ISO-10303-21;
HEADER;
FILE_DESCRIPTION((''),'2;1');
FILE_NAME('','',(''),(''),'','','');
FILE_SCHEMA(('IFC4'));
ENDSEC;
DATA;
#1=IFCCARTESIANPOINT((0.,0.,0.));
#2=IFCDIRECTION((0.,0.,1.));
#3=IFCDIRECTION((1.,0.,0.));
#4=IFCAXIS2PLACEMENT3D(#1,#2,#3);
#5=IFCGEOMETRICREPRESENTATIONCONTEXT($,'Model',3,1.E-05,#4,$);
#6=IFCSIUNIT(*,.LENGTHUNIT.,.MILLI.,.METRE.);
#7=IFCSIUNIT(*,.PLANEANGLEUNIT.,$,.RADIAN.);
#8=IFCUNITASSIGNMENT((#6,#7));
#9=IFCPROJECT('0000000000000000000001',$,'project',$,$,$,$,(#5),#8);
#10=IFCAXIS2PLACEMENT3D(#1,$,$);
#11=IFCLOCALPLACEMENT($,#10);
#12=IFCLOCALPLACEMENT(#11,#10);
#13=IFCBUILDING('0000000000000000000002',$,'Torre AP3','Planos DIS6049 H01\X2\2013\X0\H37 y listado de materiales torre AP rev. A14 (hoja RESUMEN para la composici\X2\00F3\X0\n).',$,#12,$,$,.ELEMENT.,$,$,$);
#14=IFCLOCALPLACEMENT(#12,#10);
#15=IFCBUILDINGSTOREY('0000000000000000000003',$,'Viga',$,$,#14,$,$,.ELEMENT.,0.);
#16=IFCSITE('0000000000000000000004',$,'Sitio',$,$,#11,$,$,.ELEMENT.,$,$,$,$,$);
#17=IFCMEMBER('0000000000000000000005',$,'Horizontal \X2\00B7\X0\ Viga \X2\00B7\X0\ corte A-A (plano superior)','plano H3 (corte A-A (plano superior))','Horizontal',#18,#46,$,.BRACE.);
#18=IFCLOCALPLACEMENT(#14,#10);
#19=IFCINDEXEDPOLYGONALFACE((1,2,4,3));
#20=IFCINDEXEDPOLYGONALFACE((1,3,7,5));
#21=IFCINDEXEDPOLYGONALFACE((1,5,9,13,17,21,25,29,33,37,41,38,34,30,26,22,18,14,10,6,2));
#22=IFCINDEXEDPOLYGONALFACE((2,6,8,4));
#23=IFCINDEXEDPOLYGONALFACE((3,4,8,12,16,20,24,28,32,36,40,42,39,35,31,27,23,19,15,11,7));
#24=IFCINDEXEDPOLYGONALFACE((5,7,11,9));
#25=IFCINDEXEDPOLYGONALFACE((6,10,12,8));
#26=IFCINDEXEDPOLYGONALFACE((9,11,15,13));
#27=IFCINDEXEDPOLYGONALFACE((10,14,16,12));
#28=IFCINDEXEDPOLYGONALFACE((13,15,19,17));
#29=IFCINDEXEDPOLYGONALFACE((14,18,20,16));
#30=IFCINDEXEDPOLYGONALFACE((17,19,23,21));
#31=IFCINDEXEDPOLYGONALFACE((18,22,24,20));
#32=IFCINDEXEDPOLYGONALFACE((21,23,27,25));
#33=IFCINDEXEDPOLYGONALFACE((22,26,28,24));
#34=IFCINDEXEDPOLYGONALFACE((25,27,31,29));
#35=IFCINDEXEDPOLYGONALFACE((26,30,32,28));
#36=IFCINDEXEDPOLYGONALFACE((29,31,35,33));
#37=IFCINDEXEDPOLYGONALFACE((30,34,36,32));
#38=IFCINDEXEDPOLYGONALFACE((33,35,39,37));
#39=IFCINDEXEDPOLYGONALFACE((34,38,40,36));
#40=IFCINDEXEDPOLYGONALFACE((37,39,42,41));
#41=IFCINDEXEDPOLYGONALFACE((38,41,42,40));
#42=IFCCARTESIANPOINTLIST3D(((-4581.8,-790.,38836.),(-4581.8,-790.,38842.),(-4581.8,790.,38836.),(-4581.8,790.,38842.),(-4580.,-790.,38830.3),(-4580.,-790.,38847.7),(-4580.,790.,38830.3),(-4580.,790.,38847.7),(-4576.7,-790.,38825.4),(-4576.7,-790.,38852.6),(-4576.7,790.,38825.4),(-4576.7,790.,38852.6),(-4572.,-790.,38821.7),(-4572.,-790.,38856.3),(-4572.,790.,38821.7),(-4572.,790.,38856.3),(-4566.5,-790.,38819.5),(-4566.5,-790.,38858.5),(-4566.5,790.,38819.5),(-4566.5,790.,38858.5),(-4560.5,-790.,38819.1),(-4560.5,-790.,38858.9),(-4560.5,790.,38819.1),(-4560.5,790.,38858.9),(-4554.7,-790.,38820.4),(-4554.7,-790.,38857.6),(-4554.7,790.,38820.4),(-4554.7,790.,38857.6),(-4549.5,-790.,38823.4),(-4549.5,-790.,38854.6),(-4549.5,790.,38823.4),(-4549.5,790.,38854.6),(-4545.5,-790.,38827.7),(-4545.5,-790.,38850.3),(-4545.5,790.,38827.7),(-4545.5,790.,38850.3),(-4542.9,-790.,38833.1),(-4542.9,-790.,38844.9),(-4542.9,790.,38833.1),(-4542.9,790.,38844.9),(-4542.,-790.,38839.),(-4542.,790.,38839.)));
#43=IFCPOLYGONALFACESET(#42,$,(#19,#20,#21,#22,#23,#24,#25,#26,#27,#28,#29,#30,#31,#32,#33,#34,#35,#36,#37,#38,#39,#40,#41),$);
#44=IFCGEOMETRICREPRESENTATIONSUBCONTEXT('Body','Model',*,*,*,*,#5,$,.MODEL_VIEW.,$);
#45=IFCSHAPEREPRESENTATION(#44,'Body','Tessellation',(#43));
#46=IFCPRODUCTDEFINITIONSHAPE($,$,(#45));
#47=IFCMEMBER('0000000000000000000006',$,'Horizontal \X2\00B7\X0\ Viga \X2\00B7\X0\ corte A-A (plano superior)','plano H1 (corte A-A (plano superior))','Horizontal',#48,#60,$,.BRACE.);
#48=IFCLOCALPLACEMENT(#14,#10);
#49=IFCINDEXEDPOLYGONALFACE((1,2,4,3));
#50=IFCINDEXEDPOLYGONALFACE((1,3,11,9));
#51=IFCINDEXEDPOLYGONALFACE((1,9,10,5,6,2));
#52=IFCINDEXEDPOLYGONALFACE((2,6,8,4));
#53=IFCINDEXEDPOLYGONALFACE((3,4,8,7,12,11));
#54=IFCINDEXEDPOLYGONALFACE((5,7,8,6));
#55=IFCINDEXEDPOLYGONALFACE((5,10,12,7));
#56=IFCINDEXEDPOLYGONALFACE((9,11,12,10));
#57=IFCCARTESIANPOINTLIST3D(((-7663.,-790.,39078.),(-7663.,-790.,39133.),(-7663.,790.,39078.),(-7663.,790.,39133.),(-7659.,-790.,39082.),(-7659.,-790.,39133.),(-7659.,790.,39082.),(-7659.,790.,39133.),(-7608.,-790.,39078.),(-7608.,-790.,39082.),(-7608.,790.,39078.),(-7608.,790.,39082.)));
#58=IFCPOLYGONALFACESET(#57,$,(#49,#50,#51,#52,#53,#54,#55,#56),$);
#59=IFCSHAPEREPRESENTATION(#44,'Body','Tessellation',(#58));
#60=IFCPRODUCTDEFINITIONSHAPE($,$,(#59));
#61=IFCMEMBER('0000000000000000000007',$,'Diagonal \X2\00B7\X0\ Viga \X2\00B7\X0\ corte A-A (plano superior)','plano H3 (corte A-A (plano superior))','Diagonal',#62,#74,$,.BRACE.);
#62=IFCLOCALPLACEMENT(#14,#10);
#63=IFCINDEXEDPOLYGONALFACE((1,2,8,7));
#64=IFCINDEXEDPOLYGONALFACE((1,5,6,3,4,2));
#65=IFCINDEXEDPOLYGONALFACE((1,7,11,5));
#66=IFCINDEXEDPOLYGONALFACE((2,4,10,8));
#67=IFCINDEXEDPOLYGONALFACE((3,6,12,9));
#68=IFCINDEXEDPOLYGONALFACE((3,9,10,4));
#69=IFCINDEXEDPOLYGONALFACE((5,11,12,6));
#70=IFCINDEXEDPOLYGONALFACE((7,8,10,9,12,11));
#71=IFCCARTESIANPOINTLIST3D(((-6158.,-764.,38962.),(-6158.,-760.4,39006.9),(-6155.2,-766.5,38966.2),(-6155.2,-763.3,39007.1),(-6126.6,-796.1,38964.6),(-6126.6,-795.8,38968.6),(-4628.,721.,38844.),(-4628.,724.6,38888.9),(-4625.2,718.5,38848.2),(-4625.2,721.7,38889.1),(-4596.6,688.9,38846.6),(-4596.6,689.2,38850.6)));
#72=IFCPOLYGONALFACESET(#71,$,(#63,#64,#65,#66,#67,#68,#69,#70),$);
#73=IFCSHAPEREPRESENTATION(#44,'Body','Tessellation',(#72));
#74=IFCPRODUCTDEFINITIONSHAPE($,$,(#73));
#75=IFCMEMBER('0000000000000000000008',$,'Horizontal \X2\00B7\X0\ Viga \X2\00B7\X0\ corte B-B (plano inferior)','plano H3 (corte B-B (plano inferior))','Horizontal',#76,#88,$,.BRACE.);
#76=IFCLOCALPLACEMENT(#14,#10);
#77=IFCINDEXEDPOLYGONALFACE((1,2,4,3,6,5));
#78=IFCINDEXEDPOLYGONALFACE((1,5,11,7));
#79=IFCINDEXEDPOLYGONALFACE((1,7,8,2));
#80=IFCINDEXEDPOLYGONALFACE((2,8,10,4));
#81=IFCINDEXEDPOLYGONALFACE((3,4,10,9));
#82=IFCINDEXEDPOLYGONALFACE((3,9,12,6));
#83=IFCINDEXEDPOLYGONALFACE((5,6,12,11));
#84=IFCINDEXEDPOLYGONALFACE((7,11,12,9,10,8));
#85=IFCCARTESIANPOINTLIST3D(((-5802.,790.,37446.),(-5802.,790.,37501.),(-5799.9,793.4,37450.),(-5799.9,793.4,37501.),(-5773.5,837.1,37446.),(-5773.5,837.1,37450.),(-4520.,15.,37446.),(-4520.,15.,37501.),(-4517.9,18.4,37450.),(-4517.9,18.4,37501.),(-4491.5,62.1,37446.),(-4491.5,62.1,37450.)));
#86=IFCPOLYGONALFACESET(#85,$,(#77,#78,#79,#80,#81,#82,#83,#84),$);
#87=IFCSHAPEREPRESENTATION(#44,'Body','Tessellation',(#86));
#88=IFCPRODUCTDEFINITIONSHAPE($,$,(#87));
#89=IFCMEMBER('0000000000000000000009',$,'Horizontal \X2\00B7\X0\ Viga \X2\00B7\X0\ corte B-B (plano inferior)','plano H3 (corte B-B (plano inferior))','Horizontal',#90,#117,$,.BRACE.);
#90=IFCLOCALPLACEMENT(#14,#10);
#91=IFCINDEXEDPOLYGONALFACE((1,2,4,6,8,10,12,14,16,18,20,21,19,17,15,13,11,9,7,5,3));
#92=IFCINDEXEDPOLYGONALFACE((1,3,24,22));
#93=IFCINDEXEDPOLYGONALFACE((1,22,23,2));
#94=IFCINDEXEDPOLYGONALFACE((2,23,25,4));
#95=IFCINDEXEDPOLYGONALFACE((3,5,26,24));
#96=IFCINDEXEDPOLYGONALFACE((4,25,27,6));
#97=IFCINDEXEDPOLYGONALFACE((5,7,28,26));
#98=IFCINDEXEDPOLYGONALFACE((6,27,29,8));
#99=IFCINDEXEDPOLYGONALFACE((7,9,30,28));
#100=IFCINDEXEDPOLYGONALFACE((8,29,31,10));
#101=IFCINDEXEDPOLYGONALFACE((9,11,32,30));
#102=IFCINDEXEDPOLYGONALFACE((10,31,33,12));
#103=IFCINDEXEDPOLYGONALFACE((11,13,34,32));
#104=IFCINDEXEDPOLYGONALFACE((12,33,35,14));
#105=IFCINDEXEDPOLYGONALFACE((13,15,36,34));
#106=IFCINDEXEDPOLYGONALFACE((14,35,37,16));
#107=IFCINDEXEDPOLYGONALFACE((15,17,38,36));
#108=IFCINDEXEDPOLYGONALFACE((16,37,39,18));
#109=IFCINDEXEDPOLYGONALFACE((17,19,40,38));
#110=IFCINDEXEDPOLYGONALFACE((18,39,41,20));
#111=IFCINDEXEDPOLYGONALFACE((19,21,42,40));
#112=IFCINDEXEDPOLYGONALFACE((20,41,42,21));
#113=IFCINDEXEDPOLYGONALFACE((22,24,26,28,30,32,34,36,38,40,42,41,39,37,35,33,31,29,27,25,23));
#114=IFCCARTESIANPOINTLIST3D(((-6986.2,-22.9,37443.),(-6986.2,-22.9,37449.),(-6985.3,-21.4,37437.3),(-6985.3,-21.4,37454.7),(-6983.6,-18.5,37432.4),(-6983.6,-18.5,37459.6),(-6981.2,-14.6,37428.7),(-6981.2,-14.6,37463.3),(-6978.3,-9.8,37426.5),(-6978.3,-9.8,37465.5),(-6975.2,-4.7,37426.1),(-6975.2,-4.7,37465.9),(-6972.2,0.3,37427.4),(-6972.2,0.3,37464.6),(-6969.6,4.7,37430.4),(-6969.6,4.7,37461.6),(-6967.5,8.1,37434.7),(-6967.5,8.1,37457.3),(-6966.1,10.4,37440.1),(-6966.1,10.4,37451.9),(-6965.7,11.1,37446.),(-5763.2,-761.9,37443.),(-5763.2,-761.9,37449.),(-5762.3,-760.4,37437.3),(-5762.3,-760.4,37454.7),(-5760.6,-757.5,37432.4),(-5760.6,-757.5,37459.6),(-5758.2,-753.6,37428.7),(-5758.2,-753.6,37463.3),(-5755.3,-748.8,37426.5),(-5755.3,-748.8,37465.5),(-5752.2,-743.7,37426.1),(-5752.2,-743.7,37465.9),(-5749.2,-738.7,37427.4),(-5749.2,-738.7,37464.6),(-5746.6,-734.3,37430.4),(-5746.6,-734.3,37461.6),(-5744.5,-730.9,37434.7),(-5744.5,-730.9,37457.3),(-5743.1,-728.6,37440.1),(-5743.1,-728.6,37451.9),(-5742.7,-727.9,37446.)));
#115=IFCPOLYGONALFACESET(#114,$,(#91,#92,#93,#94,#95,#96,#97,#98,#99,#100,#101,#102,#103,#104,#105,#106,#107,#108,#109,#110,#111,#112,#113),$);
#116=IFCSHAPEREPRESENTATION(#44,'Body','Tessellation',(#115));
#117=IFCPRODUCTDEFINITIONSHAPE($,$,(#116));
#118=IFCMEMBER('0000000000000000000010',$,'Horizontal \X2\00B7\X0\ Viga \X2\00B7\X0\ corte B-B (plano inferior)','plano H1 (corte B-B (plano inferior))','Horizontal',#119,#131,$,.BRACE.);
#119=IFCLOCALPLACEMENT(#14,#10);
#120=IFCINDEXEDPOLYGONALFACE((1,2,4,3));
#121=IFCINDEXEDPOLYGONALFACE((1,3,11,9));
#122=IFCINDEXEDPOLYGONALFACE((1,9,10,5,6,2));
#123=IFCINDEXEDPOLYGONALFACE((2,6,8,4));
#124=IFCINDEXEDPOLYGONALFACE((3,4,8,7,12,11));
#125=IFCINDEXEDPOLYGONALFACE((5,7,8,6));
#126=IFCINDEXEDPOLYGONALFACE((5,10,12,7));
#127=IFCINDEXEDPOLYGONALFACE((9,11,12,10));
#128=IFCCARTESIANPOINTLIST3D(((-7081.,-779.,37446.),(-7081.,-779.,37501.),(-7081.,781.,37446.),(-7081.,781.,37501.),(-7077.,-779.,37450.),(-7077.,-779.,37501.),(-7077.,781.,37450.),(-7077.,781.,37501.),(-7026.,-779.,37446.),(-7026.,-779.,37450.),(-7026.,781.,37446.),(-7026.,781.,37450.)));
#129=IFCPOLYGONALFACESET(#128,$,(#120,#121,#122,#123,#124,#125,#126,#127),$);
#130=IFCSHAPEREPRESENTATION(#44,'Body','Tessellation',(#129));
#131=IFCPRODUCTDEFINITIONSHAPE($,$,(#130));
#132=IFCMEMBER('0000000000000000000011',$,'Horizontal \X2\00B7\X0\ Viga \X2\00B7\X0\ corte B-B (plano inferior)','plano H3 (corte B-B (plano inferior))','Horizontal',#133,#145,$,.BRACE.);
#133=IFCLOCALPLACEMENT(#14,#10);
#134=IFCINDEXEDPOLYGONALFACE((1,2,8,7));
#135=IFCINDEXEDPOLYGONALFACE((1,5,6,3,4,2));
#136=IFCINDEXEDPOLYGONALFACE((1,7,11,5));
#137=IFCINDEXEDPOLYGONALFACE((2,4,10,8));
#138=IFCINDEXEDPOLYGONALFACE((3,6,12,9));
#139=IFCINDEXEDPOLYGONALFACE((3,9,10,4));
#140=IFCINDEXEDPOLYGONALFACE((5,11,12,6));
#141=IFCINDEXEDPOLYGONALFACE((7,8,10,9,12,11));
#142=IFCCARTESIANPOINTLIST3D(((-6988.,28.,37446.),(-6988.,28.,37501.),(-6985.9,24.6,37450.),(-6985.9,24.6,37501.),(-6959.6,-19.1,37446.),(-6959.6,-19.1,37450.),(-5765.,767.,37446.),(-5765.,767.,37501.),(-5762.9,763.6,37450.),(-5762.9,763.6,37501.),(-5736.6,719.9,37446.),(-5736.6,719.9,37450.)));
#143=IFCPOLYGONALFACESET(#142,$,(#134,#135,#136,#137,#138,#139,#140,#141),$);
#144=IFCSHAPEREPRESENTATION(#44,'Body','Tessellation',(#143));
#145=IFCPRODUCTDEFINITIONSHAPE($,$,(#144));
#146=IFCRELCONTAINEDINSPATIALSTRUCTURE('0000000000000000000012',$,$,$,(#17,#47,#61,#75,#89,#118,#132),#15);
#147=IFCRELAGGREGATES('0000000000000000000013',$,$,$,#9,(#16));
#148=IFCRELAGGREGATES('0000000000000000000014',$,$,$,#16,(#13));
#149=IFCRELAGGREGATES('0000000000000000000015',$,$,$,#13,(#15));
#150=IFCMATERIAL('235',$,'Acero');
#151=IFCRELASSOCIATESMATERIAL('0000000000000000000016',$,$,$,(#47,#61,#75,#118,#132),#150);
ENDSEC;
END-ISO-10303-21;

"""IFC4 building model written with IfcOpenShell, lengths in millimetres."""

from ifc_helpers import new_model, si_unit, frame, frame_2d, origin, origin_with_axes, place, context, subcontext, project, spatial, circle, l_section, extrude, material, element, save


model = new_model("IFC4")

# Units and contexts
model_context = context("Model", 3, precision=1e-05, world=origin_with_axes())
body_context = subcontext(model_context, "Body", "Model", "MODEL_VIEW")
ifc_project = project(units=[si_unit("LENGTHUNIT", "METRE", prefix="MILLI"), si_unit("PLANEANGLEUNIT", "RADIAN")], contexts=[model_context])

# Site, building, storey
site_placement = place(None, origin())
site = spatial("IfcSite", under=ifc_project, at=site_placement, Name="Sitio", CompositionType="ELEMENT")
building_placement = place(site_placement, origin())
building = spatial("IfcBuilding", under=site, at=building_placement, Name="Torre AP3", Description="Planos DIS6049 H01–H37 y listado de materiales torre AP rev. A14 (hoja RESUMEN para la composición).", CompositionType="ELEMENT")
storey_placement = place(building_placement, origin())
storey = spatial("IfcBuildingStorey", under=building, at=storey_placement, Name="Viga", CompositionType="ELEMENT", Elevation=0.0)

# Members
ifc_material_1 = material(Name="235", Category="Acero")
member_1_placement = place(storey_placement, frame((-4562.0, 790.0, 38839.0), z_axis=(0.0, -1.0, 0.0), x_axis=(1.0, 0.0, 0.0)))
element("IfcMember", 1, at=member_1_placement, inside=storey, Name="Horizontal · Viga · corte A-A (plano superior)", Description="plano H3 (corte A-A (plano superior))", ObjectType="Horizontal", PredefinedType="BRACE", context=body_context, shape_type="SweptSolid", body=[
    extrude(circle(Radius=20.0), None, (0.0, 0.0, 1.0), 1580.0),
])
member_2_placement = place(storey_placement, frame((-7663.0, 790.0, 39078.0), z_axis=(0.0, -1.0, 0.0), x_axis=(1.0, 0.0, 0.0)))
element("IfcMember", 2, at=member_2_placement, inside=storey, material=ifc_material_1, Name="Horizontal · Viga · corte A-A (plano superior)", Description="plano H1 (corte A-A (plano superior))", ObjectType="Horizontal", PredefinedType="BRACE", context=body_context, shape_type="SweptSolid", body=[
    extrude(l_section(Depth=55.0, Width=55.0, Thickness=4.0, at=frame_2d((27.5, 27.5))), None, (0.0, 0.0, 1.0), 1580.0),
])
member_3_placement = place(storey_placement, frame((-4628.0, 721.0, 38844.0), z_axis=(-0.716484, -0.695411, 0.055258), x_axis=(0.697603, -0.714197, 0.057207)))
element("IfcMember", 3, at=member_3_placement, inside=storey, material=ifc_material_1, Name="Diagonal · Viga · corte A-A (plano superior)", Description="plano H3 (corte A-A (plano superior))", ObjectType="Diagonal", PredefinedType="BRACE", context=body_context, shape_type="SweptSolid", body=[
    extrude(l_section(Depth=45.0, Width=45.0, Thickness=4.0, at=frame_2d((22.5, 22.5))), None, (0.0, 0.0, 1.0), 2135.4),
])
member_4_placement = place(storey_placement, frame((-5802.0, 790.0, 37446.0), z_axis=(0.85578, -0.51734, 0.0), x_axis=(0.51734, 0.85578, 0.0)))
element("IfcMember", 4, at=member_4_placement, inside=storey, material=ifc_material_1, Name="Horizontal · Viga · corte B-B (plano inferior)", Description="plano H3 (corte B-B (plano inferior))", ObjectType="Horizontal", PredefinedType="BRACE", context=body_context, shape_type="SweptSolid", body=[
    extrude(l_section(Depth=55.0, Width=55.0, Thickness=4.0, at=frame_2d((27.5, 27.5))), None, (0.0, 0.0, 1.0), 1498.0),
])
member_5_placement = place(storey_placement, frame((-6976.0, -6.0, 37446.0), z_axis=(0.855883, -0.517169, 0.0), x_axis=(0.517169, 0.855883, 0.0)))
element("IfcMember", 5, at=member_5_placement, inside=storey, Name="Horizontal · Viga · corte B-B (plano inferior)", Description="plano H3 (corte B-B (plano inferior))", ObjectType="Horizontal", PredefinedType="BRACE", context=body_context, shape_type="SweptSolid", body=[
    extrude(circle(Radius=20.0), None, (0.0, 0.0, 1.0), 1428.9),
])
member_6_placement = place(storey_placement, frame((-7081.0, 781.0, 37446.0), z_axis=(0.0, -1.0, 0.0), x_axis=(1.0, 0.0, 0.0)))
element("IfcMember", 6, at=member_6_placement, inside=storey, material=ifc_material_1, Name="Horizontal · Viga · corte B-B (plano inferior)", Description="plano H1 (corte B-B (plano inferior))", ObjectType="Horizontal", PredefinedType="BRACE", context=body_context, shape_type="SweptSolid", body=[
    extrude(l_section(Depth=55.0, Width=55.0, Thickness=4.0, at=frame_2d((27.5, 27.5))), None, (0.0, 0.0, 1.0), 1560.0),
])
member_7_placement = place(storey_placement, frame((-5765.0, 767.0, 37446.0), z_axis=(-0.855883, -0.517169, 0.0), x_axis=(0.517169, -0.855883, 0.0)))
element("IfcMember", 7, at=member_7_placement, inside=storey, material=ifc_material_1, Name="Horizontal · Viga · corte B-B (plano inferior)", Description="plano H3 (corte B-B (plano inferior))", ObjectType="Horizontal", PredefinedType="BRACE", context=body_context, shape_type="SweptSolid", body=[
    extrude(l_section(Depth=55.0, Width=55.0, Thickness=4.0, at=frame_2d((27.5, 27.5))), None, (0.0, 0.0, 1.0), 1428.9),
])

save(model, "model.ifc")
